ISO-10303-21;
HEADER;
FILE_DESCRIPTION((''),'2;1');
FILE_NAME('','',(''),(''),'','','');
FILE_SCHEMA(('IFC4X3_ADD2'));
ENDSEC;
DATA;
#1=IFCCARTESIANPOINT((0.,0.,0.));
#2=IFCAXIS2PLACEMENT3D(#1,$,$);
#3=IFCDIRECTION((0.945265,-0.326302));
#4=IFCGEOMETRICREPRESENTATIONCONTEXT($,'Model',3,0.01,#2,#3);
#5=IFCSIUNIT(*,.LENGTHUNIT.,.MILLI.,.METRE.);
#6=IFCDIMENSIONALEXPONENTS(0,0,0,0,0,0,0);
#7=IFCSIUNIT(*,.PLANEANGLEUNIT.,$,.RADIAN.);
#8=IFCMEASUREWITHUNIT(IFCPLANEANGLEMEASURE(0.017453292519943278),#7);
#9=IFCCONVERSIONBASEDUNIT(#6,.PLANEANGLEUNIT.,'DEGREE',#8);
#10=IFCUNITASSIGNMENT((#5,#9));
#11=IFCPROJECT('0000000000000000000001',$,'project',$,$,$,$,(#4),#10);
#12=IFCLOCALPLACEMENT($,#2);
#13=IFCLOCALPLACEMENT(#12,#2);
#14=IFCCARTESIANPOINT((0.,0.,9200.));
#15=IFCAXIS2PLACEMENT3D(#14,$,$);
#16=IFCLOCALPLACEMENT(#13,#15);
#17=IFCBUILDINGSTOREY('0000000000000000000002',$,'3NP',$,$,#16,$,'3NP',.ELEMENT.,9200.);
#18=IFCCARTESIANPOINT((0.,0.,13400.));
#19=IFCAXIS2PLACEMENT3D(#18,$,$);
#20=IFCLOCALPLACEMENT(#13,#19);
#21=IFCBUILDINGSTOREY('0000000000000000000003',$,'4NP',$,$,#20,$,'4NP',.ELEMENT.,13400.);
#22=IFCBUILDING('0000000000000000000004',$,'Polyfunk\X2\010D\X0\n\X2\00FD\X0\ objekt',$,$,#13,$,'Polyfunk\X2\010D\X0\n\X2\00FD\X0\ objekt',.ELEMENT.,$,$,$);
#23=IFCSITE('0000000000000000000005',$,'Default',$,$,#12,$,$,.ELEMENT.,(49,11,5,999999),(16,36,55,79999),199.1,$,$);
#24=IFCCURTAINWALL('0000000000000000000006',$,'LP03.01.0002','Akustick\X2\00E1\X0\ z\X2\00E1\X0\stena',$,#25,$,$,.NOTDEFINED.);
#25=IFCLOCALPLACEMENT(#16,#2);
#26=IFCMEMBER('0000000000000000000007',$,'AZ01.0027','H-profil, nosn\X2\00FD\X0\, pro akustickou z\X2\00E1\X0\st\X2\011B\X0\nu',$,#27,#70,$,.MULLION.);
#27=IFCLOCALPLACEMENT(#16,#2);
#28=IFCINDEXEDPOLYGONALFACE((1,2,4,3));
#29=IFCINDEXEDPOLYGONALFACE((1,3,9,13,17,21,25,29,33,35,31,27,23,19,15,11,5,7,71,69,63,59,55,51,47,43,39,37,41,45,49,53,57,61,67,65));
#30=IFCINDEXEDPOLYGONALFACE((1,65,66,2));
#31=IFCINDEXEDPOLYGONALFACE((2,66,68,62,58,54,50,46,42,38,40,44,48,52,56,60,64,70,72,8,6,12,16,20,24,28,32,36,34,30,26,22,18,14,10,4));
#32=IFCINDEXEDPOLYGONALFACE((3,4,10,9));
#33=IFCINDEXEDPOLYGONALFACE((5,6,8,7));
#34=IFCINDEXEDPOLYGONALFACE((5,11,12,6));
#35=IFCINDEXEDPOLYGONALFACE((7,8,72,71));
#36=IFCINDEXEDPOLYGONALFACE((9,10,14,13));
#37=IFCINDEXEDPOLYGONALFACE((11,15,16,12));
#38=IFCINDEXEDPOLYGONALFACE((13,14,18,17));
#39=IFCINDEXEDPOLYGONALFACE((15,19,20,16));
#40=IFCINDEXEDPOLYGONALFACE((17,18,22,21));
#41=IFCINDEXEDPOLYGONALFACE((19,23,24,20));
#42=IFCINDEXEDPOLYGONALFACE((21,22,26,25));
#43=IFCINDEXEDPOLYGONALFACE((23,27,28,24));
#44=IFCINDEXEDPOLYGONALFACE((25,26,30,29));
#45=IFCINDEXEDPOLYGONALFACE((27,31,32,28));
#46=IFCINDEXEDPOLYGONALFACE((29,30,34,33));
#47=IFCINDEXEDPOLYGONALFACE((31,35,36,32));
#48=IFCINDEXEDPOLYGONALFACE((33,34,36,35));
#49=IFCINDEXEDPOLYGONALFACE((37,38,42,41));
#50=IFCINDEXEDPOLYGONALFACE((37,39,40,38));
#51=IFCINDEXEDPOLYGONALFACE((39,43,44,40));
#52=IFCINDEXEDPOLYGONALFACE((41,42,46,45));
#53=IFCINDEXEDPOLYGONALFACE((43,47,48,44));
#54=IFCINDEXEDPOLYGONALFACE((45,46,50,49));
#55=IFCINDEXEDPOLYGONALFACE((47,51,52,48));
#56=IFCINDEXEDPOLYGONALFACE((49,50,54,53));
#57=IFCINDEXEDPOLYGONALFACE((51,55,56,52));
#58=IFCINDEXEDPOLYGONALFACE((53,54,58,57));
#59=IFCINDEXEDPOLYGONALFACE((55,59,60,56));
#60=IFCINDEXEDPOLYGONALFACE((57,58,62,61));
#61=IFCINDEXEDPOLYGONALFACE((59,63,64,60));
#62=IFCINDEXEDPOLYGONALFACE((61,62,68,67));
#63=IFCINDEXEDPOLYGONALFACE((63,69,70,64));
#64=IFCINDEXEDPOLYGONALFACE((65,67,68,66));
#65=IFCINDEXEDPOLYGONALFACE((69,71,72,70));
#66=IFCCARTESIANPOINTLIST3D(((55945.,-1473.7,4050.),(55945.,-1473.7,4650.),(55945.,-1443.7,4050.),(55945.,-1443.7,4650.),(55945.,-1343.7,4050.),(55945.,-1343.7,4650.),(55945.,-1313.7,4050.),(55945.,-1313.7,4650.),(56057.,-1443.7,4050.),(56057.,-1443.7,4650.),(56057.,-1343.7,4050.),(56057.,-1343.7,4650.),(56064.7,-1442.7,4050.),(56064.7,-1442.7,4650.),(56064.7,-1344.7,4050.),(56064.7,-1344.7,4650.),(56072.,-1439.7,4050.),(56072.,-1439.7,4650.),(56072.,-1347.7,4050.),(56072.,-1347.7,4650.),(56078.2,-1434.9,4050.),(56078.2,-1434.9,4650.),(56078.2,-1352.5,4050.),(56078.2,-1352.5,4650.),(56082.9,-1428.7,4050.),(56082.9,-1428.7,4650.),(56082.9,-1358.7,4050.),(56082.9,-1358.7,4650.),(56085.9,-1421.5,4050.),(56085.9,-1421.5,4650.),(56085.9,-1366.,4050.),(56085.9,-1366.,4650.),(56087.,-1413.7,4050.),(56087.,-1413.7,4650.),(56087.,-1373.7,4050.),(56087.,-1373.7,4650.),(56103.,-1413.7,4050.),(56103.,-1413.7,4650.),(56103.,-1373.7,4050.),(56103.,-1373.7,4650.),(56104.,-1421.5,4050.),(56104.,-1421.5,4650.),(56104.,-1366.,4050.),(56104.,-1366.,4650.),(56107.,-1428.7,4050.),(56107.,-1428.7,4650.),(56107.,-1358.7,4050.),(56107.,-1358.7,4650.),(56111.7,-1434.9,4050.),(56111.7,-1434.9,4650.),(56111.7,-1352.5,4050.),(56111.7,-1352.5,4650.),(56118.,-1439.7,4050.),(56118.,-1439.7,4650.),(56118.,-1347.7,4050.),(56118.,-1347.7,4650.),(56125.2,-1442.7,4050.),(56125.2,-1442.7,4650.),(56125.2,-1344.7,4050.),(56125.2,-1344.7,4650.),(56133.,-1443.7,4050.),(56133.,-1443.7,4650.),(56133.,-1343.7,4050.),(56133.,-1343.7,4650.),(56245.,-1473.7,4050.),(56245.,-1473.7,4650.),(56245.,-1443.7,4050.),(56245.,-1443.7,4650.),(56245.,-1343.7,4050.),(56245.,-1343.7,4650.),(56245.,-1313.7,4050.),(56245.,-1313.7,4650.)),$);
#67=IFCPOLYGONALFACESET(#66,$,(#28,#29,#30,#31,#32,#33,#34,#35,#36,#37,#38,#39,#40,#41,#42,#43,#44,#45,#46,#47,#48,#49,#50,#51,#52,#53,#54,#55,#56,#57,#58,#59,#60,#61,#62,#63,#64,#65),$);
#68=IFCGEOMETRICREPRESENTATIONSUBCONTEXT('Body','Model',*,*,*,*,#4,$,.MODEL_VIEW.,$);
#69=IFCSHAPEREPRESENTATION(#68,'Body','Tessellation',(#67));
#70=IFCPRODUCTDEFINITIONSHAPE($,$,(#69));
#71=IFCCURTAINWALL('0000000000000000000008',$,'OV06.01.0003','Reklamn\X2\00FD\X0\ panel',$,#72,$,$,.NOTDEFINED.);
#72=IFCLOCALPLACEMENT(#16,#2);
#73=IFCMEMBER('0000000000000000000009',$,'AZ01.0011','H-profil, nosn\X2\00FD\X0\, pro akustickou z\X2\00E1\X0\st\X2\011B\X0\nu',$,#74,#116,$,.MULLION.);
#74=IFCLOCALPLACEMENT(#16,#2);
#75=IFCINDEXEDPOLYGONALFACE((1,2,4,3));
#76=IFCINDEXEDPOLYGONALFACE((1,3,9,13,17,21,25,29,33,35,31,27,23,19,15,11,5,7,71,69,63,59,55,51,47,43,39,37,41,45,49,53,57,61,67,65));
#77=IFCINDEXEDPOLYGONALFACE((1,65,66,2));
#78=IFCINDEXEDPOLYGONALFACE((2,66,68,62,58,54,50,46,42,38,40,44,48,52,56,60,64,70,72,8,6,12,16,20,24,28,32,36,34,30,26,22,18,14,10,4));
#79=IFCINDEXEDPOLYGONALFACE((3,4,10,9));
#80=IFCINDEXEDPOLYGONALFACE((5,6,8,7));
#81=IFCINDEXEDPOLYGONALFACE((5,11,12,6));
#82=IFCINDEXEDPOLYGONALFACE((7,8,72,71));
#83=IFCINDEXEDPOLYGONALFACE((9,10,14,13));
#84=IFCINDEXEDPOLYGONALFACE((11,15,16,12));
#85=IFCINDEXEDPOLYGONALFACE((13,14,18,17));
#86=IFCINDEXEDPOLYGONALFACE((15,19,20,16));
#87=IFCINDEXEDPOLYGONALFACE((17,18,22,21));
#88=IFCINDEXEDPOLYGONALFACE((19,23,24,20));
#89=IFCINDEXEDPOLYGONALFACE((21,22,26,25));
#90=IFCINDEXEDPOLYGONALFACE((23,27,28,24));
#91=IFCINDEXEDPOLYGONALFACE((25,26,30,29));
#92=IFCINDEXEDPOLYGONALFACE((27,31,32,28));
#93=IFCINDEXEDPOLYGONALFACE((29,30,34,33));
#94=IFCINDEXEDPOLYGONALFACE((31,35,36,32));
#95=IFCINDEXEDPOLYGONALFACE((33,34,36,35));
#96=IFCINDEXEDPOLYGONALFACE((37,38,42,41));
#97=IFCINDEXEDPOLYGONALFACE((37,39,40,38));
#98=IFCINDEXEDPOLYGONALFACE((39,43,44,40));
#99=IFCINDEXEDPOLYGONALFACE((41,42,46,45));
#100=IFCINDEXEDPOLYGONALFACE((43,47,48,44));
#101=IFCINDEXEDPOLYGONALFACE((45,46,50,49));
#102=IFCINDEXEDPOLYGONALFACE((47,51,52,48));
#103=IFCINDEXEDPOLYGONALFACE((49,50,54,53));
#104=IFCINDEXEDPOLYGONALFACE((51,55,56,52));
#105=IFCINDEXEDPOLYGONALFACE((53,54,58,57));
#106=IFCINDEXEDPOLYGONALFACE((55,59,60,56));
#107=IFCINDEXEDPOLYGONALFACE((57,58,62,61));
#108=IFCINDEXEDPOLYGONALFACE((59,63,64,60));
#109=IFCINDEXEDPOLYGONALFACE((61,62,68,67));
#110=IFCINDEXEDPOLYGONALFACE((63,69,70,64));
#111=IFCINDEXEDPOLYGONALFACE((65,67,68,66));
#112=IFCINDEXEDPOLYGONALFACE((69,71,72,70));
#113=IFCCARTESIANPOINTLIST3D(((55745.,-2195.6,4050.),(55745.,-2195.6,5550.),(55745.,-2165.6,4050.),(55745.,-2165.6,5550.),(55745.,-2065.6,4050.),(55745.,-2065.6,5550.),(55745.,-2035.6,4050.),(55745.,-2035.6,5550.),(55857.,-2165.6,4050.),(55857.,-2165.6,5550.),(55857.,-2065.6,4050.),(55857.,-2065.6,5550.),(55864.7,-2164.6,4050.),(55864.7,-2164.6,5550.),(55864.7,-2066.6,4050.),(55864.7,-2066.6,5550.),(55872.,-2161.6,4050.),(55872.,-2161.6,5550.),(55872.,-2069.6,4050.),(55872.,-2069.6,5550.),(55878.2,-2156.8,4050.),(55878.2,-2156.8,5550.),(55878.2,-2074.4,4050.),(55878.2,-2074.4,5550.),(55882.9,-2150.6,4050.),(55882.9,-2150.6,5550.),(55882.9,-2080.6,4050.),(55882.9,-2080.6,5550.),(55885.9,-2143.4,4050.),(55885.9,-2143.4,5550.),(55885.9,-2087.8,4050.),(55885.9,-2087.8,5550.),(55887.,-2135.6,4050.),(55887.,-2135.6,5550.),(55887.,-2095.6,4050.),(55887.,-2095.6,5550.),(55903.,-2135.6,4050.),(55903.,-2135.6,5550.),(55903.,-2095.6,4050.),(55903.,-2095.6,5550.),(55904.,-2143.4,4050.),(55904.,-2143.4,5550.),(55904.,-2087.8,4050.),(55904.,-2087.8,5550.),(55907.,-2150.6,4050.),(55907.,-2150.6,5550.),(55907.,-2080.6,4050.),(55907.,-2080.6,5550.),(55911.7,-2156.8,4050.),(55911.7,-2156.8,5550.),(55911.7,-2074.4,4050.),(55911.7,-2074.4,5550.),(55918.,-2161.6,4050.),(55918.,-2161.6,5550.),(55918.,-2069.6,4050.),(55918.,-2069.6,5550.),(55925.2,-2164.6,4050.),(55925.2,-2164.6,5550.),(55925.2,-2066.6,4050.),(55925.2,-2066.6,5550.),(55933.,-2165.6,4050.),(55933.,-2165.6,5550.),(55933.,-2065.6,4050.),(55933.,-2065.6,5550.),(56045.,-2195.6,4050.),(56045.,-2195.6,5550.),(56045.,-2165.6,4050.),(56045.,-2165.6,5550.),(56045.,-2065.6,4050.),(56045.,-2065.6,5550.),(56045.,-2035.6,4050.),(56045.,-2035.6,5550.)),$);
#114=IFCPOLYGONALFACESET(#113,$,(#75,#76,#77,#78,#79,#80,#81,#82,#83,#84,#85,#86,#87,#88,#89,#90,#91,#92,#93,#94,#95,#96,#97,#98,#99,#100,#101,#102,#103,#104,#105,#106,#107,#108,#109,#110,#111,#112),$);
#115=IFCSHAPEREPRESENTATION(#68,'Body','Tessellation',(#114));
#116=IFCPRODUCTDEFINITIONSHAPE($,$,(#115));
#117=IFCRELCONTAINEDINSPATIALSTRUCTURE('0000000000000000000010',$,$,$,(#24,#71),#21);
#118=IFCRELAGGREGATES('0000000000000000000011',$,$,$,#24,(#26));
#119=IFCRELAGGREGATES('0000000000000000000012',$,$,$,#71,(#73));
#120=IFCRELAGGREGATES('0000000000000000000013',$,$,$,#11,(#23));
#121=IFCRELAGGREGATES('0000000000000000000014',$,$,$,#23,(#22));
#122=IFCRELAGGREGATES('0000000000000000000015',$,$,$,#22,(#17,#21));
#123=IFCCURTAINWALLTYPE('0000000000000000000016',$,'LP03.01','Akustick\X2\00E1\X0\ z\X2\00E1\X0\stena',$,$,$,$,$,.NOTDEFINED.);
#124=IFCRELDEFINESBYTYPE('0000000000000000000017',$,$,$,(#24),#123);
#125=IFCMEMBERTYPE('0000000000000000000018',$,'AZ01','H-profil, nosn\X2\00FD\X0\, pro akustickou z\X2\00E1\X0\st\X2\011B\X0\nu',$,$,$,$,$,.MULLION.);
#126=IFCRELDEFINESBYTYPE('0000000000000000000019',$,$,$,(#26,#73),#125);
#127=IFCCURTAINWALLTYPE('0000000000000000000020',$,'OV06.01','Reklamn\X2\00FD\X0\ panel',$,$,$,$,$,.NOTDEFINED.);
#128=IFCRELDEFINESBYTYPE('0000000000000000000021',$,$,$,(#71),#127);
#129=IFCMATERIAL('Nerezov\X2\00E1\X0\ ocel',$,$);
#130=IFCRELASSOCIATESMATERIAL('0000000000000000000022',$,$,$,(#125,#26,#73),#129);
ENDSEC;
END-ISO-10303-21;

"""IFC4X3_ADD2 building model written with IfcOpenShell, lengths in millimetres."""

from ifc_helpers import new_model, entity, si_unit, converted_unit, direction, frame, frame_2d, origin, place, context, subcontext, project, spatial, polyline, circle_curve, parameter, trimmed, segment, composite_curve, outline, extrude, source, transform, mapped, material, material_profile, profile_set, profile_usage, type_object, element, aggregate, save


model = new_model("IFC4X3_ADD2")

# Units and contexts
model_context = context("Model", 3, precision=0.01, world=origin(), true_north=direction((0.945265, -0.326302)))
body_context = subcontext(model_context, "Body", "Model", "MODEL_VIEW")
ifc_project = project(units=[si_unit("LENGTHUNIT", "METRE", prefix="MILLI"), converted_unit("PLANEANGLEUNIT", "DEGREE", entity("IfcPlaneAngleMeasure", 0.017453292519943278), si_unit("PLANEANGLEUNIT", "RADIAN"), dimensions=[0, 0, 0, 0, 0, 0, 0])], contexts=[model_context])

# Site, building, storey
site_placement = place(None, origin())
site = spatial("IfcSite", under=ifc_project, at=site_placement, Name="Default", CompositionType="ELEMENT", RefLatitude=(49, 11, 5, 999999), RefLongitude=(16, 36, 55, 79999), RefElevation=199.1)
building_placement = place(site_placement, origin())
building = spatial("IfcBuilding", under=site, at=building_placement, Name="Polyfunkčný objekt", LongName="Polyfunkčný objekt", CompositionType="ELEMENT")
storey_1_placement = place(building_placement, frame((0.0, 0.0, 9200.0)))
storey_1 = spatial("IfcBuildingStorey", under=building, at=storey_1_placement, Name="3NP", LongName="3NP", CompositionType="ELEMENT", Elevation=9200.0)

# Shared definitions
storey_2_placement = place(building_placement, frame((0.0, 0.0, 13400.0)))
storey_2 = spatial("IfcBuildingStorey", under=building, at=storey_2_placement, Name="4NP", LongName="4NP", CompositionType="ELEMENT", Elevation=13400.0)

# Curtain walls, members
curtain_wall_type_1 = type_object("IfcCurtainWallType", Name="LP03.01", Description="Akustická zástena", PredefinedType="NOTDEFINED")
ifc_material_1 = material(Name="Nerezová ocel")
ifc_material_profile_1 = material_profile(ifc_material_1, outline(composite_curve([segment(polyline([(50.0, -150.0), (80.0, -150.0)]), True, "CONTINUOUS"), segment(polyline([(80.0, -150.0), (80.0, 150.0)]), True, "CONTINUOUS"), segment(polyline([(80.0, 150.0), (50.0, 150.0)]), True, "CONTINUOUS"), segment(polyline([(50.0, 150.0), (50.0, 38.0)]), True, "CONTINUOUS"), segment(trimmed(circle_curve(frame_2d((20.0, 38.0), x_axis=(0.0, 1.0)), 30.0), [parameter(180.0)], [parameter(270.0)], True, "PARAMETER"), False, "CONTINUOUS"), segment(polyline([(20.0, 8.0), (-20.0, 8.0)]), True, "CONTINUOUS"), segment(trimmed(circle_curve(frame_2d((-20.0, 38.0), x_axis=(0.0, 1.0)), 30.0), [parameter(90.0)], [parameter(180.0)], True, "PARAMETER"), False, "CONTINUOUS"), segment(polyline([(-50.0, 38.0), (-50.0, 150.0)]), True, "CONTINUOUS"), segment(polyline([(-50.0, 150.0), (-80.0, 150.0)]), True, "CONTINUOUS"), segment(polyline([(-80.0, 150.0), (-80.0, -150.0)]), True, "CONTINUOUS"), segment(polyline([(-80.0, -150.0), (-50.0, -150.0)]), True, "CONTINUOUS"), segment(polyline([(-50.0, -150.0), (-50.0, -38.0)]), True, "CONTINUOUS"), segment(trimmed(circle_curve(frame_2d((-20.0, -38.0), x_axis=(0.0, 1.0)), 30.0), [parameter(0.0)], [parameter(90.0)], True, "PARAMETER"), False, "CONTINUOUS"), segment(polyline([(-20.0, -8.0), (20.0, -8.0)]), True, "CONTINUOUS"), segment(trimmed(circle_curve(frame_2d((20.0, -38.0), x_axis=(0.0, 1.0)), 30.0), [parameter(270.0)], [parameter(0.0)], True, "PARAMETER"), False, "CONTINUOUS"), segment(polyline([(50.0, -38.0), (50.0, -150.0)]), True, "CONTINUOUS")], self_intersect=False)), Name="Profil zástena")
ifc_profile_set_1 = profile_set([ifc_material_profile_1], Name="Profil zástena")
ifc_profile_usage_1 = profile_usage(ifc_profile_set_1)
member_type_1 = type_object("IfcMemberType", Name="AZ01", Description="H-profil, nosný, pro akustickou zástěnu", PredefinedType="MULLION", material=ifc_profile_set_1)
curtain_wall_1_placement = place(storey_2_placement, frame((0.0, 0.0, -13400.0)))
curtain_wall_1 = element("IfcCurtainWall", 1, at=curtain_wall_1_placement, inside=storey_2, type_object=curtain_wall_type_1, Name="LP03.01.0002", Description="Akustická zástena", PredefinedType="NOTDEFINED")
shared_shape_1 = source(origin(), body_context, "Body", "SweptSolid", [
    extrude(outline(composite_curve([segment(polyline([(50.0, -150.0), (80.0, -150.0)]), True, "CONTINUOUS"), segment(polyline([(80.0, -150.0), (80.0, 150.0)]), True, "CONTINUOUS"), segment(polyline([(80.0, 150.0), (50.0, 150.0)]), True, "CONTINUOUS"), segment(polyline([(50.0, 150.0), (50.0, 38.0)]), True, "CONTINUOUS"), segment(trimmed(circle_curve(frame_2d((20.0, 38.0), x_axis=(0.0, 1.0)), 30.0), [parameter(180.0)], [parameter(270.0)], True, "PARAMETER"), False, "CONTINUOUS"), segment(polyline([(20.0, 8.0), (-20.0, 8.0)]), True, "CONTINUOUS"), segment(trimmed(circle_curve(frame_2d((-20.0, 38.0), x_axis=(0.0, 1.0)), 30.0), [parameter(90.0)], [parameter(180.0)], True, "PARAMETER"), False, "CONTINUOUS"), segment(polyline([(-50.0, 38.0), (-50.0, 150.0)]), True, "CONTINUOUS"), segment(polyline([(-50.0, 150.0), (-80.0, 150.0)]), True, "CONTINUOUS"), segment(polyline([(-80.0, 150.0), (-80.0, -150.0)]), True, "CONTINUOUS"), segment(polyline([(-80.0, -150.0), (-50.0, -150.0)]), True, "CONTINUOUS"), segment(polyline([(-50.0, -150.0), (-50.0, -38.0)]), True, "CONTINUOUS"), segment(trimmed(circle_curve(frame_2d((-20.0, -38.0), x_axis=(0.0, 1.0)), 30.0), [parameter(0.0)], [parameter(90.0)], True, "PARAMETER"), False, "CONTINUOUS"), segment(polyline([(-20.0, -8.0), (20.0, -8.0)]), True, "CONTINUOUS"), segment(trimmed(circle_curve(frame_2d((20.0, -38.0), x_axis=(0.0, 1.0)), 30.0), [parameter(270.0)], [parameter(0.0)], True, "PARAMETER"), False, "CONTINUOUS"), segment(polyline([(50.0, -38.0), (50.0, -150.0)]), True, "CONTINUOUS")], self_intersect=False)), frame((-150.0, 0.0, -600.0), z_axis=(0.0, 0.0, 1.0), x_axis=(0.0, -1.0, 0.0)), (0.0, 0.0, 1.0), 600.0),
])
member_1_placement = place(curtain_wall_1_placement, frame((56245.0, -1393.7, 13250.0), z_axis=(0.0, 0.0, -1.0), x_axis=(1.0, 0.0, 0.0)))
member_1 = element("IfcMember", 2, at=member_1_placement, type_object=member_type_1, material=ifc_profile_usage_1, Name="AZ01.0027", Description="H-profil, nosný, pro akustickou zástěnu", PredefinedType="MULLION", context=body_context, shape_type="MappedRepresentation", body=[
    mapped(shared_shape_1, transform((0.0, 0.0, 0.0), scale=1.0)),
])
aggregate(curtain_wall_1, [member_1])
curtain_wall_type_2 = type_object("IfcCurtainWallType", Name="OV06.01", Description="Reklamný panel", PredefinedType="NOTDEFINED")
curtain_wall_2_placement = place(storey_2_placement, frame((0.0, 0.0, -13400.0)))
curtain_wall_2 = element("IfcCurtainWall", 3, at=curtain_wall_2_placement, inside=storey_2, type_object=curtain_wall_type_2, Name="OV06.01.0003", Description="Reklamný panel", PredefinedType="NOTDEFINED")
shared_shape_2 = source(origin(), body_context, "Body", "SweptSolid", [
    extrude(outline(composite_curve([segment(polyline([(-150.0, -50.0), (-150.0, -80.0)]), True, "CONTINUOUS"), segment(polyline([(-150.0, -80.0), (150.0, -80.0)]), True, "CONTINUOUS"), segment(polyline([(150.0, -80.0), (150.0, -50.0)]), True, "CONTINUOUS"), segment(polyline([(150.0, -50.0), (38.0, -50.0)]), True, "CONTINUOUS"), segment(trimmed(circle_curve(frame_2d((38.0, -20.0), x_axis=(1.0, 0.0)), 30.0), [parameter(180.0)], [parameter(270.0)], True, "PARAMETER"), False, "CONTINUOUS"), segment(polyline([(8.0, -20.0), (8.0, 20.0)]), True, "CONTINUOUS"), segment(trimmed(circle_curve(frame_2d((38.0, 20.0), x_axis=(1.0, 0.0)), 30.0), [parameter(90.0)], [parameter(180.0)], True, "PARAMETER"), False, "CONTINUOUS"), segment(polyline([(38.0, 50.0), (150.0, 50.0)]), True, "CONTINUOUS"), segment(polyline([(150.0, 50.0), (150.0, 80.0)]), True, "CONTINUOUS"), segment(polyline([(150.0, 80.0), (-150.0, 80.0)]), True, "CONTINUOUS"), segment(polyline([(-150.0, 80.0), (-150.0, 50.0)]), True, "CONTINUOUS"), segment(polyline([(-150.0, 50.0), (-38.0, 50.0)]), True, "CONTINUOUS"), segment(trimmed(circle_curve(frame_2d((-38.0, 20.0), x_axis=(1.0, 0.0)), 30.0), [parameter(0.0)], [parameter(90.0)], True, "PARAMETER"), False, "CONTINUOUS"), segment(polyline([(-8.0, 20.0), (-8.0, -20.0)]), True, "CONTINUOUS"), segment(trimmed(circle_curve(frame_2d((-38.0, -20.0), x_axis=(1.0, 0.0)), 30.0), [parameter(270.0)], [parameter(0.0)], True, "PARAMETER"), False, "CONTINUOUS"), segment(polyline([(-38.0, -50.0), (-150.0, -50.0)]), True, "CONTINUOUS")], self_intersect=False)), frame((-150.0, 0.0, -1500.0), z_axis=(0.0, 0.0, -1.0), x_axis=(1.0, 0.0, 0.0)), (0.0, 0.0, -1.0), 1500.0),
])
member_2_placement = place(curtain_wall_2_placement, frame((56045.0, -2115.6, 13250.0), z_axis=(0.0, 0.0, -1.0), x_axis=(1.0, 0.0, 0.0)))
member_2 = element("IfcMember", 4, at=member_2_placement, type_object=member_type_1, material=ifc_profile_usage_1, Name="AZ01.0011", Description="H-profil, nosný, pro akustickou zástěnu", PredefinedType="MULLION", context=body_context, shape_type="MappedRepresentation", body=[
    mapped(shared_shape_2, transform((0.0, 0.0, 0.0), scale=1.0)),
])
aggregate(curtain_wall_2, [member_2])

save(model, "model.ifc")
